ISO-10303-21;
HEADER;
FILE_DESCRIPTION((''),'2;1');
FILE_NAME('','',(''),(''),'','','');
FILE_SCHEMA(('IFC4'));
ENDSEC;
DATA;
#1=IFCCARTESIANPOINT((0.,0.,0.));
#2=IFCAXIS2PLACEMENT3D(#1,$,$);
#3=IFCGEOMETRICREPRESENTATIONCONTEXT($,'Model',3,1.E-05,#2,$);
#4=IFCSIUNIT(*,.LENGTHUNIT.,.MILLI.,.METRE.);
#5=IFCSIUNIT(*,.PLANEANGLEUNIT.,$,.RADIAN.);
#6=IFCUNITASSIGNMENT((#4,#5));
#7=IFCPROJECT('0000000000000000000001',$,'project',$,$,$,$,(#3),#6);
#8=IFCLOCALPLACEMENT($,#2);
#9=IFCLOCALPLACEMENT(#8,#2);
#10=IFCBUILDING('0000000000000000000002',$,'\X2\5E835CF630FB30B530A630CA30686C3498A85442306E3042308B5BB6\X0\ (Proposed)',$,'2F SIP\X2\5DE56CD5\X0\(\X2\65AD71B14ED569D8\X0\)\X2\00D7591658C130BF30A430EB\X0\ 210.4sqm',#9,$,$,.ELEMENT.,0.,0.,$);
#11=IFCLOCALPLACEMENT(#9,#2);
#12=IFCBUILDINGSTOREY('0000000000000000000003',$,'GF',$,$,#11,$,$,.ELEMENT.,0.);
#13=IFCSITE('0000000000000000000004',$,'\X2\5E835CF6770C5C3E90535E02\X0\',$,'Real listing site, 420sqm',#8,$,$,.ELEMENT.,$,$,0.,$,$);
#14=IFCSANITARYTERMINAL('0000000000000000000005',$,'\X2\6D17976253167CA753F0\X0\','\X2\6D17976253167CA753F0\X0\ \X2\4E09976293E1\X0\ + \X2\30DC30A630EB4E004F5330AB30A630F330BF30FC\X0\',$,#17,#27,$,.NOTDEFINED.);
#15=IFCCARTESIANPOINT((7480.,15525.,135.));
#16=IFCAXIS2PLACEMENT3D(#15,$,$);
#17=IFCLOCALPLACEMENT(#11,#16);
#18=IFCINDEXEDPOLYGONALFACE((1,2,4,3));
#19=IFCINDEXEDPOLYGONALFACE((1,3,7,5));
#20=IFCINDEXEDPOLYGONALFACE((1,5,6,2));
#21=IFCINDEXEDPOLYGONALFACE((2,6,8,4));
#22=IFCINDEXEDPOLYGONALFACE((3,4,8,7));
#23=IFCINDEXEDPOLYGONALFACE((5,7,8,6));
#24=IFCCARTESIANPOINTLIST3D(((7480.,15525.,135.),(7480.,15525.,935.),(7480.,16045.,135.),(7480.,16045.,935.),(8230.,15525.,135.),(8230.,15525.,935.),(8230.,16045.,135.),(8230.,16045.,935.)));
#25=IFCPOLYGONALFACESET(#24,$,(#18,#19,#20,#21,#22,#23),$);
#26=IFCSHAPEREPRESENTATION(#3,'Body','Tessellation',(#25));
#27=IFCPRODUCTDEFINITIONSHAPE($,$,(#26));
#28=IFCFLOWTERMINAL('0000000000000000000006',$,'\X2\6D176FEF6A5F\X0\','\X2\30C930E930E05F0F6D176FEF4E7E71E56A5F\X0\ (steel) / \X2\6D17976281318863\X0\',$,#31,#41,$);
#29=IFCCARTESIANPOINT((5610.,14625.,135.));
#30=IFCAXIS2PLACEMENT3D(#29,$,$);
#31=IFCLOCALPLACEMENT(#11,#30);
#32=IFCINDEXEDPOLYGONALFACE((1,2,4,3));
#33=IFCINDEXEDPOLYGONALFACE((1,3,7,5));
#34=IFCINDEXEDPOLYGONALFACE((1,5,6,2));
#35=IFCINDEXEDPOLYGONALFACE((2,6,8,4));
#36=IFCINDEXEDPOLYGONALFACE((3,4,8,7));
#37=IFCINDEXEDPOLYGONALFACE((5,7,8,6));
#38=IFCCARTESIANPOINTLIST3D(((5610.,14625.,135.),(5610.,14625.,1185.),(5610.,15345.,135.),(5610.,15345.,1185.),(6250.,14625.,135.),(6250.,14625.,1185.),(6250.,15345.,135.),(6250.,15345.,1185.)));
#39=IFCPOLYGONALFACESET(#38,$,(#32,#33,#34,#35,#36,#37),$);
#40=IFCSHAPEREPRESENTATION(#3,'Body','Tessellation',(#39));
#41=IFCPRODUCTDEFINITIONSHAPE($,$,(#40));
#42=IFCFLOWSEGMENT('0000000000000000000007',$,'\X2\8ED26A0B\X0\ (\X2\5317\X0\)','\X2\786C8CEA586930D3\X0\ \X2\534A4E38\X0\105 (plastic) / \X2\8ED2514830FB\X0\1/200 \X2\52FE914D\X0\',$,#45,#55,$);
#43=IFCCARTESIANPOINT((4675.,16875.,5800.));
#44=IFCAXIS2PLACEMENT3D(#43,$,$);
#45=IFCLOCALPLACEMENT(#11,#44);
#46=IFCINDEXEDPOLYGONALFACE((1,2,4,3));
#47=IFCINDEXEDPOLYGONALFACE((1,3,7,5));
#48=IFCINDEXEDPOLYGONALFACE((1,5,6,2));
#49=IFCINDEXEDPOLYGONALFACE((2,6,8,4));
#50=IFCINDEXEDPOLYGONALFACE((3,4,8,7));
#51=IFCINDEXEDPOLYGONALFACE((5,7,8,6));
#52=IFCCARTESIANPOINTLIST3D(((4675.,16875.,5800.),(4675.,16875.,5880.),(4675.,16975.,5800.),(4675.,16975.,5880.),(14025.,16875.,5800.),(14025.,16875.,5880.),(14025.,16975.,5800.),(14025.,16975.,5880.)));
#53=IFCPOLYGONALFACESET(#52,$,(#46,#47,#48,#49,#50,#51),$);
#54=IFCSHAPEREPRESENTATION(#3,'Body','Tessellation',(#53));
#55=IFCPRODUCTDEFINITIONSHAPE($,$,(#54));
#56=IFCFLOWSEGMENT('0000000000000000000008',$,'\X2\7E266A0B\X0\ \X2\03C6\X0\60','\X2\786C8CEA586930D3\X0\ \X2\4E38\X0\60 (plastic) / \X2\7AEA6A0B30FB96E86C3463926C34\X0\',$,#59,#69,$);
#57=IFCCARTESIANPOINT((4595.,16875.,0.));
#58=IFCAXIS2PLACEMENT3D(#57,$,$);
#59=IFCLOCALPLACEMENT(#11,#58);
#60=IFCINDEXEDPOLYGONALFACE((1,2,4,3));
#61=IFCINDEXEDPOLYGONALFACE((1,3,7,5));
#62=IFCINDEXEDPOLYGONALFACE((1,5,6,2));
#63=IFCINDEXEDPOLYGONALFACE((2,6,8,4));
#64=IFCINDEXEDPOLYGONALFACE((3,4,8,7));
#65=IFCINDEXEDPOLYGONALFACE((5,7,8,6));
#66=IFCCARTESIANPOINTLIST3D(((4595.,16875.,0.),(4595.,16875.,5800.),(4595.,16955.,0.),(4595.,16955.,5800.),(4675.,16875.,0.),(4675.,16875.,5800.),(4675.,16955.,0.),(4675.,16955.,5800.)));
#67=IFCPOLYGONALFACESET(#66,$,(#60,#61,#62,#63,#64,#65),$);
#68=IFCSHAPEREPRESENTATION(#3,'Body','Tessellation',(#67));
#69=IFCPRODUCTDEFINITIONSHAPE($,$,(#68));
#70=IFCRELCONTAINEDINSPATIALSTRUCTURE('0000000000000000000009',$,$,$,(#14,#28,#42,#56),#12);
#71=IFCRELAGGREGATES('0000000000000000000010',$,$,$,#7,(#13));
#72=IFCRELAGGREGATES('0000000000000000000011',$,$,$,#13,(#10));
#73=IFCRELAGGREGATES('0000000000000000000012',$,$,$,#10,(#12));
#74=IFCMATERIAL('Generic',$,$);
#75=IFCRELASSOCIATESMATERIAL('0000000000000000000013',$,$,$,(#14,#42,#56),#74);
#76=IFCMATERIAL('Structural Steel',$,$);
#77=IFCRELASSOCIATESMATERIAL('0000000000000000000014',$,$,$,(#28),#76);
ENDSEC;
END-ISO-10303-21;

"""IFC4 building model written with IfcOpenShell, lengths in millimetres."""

from ifc_helpers import new_model, si_unit, frame, frame_2d, origin, place, context, project, spatial, rectangle, extrude, material, element, save


model = new_model("IFC4")

# Units and contexts
model_context = context("Model", 3, precision=1e-05, world=origin())
ifc_project = project(units=[si_unit("LENGTHUNIT", "METRE", prefix="MILLI"), si_unit("PLANEANGLEUNIT", "RADIAN")], contexts=[model_context])

# Site, building, storey
site_placement = place(None, origin())
site = spatial("IfcSite", under=ifc_project, at=site_placement, Name="広島県尾道市", ObjectType="Real listing site, 420sqm", CompositionType="ELEMENT", RefElevation=0.0)
building_placement = place(site_placement, origin())
building = spatial("IfcBuilding", under=site, at=building_placement, Name="広島・サウナと水風呂のある家 (Proposed)", ObjectType="2F SIP工法(断熱仕様)×外壁タイル 210.4sqm", CompositionType="ELEMENT", ElevationOfRefHeight=0.0, ElevationOfTerrain=0.0)
storey_placement = place(building_placement, origin())
storey = spatial("IfcBuildingStorey", under=building, at=storey_placement, Name="GF", CompositionType="ELEMENT", Elevation=0.0)

# Sanitary terminal
ifc_material_1 = material(Name="Generic")
sanitary_terminal_placement = place(storey_placement, frame((7480.0, 15525.0, 135.0)))
element("IfcSanitaryTerminal", 1, at=sanitary_terminal_placement, inside=storey, material=ifc_material_1, Name="洗面化粧台", Description="洗面化粧台 三面鏡 + ボウル一体カウンター", PredefinedType="NOTDEFINED", context=model_context, shape_type="SweptSolid", body=[
    extrude(rectangle(XDim=750.0, YDim=520.0, at=frame_2d((375.0, 260.0))), frame((7480.0, 15525.0, 135.0)), (0.0, 0.0, 1.0), 800.0),
])

# Flow terminal
ifc_material_2 = material(Name="Structural Steel")
flow_terminal_placement = place(storey_placement, frame((5610.0, 14625.0, 135.0)))
element("IfcFlowTerminal", 2, at=flow_terminal_placement, inside=storey, material=ifc_material_2, Name="洗濯機", Description="ドラム式洗濯乾燥機 (steel) / 洗面脱衣", context=model_context, shape_type="SweptSolid", body=[
    extrude(rectangle(XDim=640.0, YDim=720.0, at=frame_2d((320.0, 360.0))), frame((5610.0, 14625.0, 135.0)), (0.0, 0.0, 1.0), 1050.0),
])

# Flow segments
flow_segment_1_placement = place(storey_placement, frame((4675.0, 16875.0, 5800.0)))
element("IfcFlowSegment", 3, at=flow_segment_1_placement, inside=storey, material=ifc_material_1, Name="軒樋 (北)", Description="硬質塩ビ 半丸105 (plastic) / 軒先・1/200 勾配", context=model_context, shape_type="SweptSolid", body=[
    extrude(rectangle(XDim=9350.0, YDim=100.0, at=frame_2d((4675.0, 50.0))), frame((4675.0, 16875.0, 5800.0)), (0.0, 0.0, 1.0), 80.0),
])
flow_segment_2_placement = place(storey_placement, frame((4595.0, 16875.0, 0.0)))
element("IfcFlowSegment", 4, at=flow_segment_2_placement, inside=storey, material=ifc_material_1, Name="縦樋 φ60", Description="硬質塩ビ 丸60 (plastic) / 竪樋・雨水排水", context=model_context, shape_type="SweptSolid", body=[
    extrude(rectangle(XDim=80.0, YDim=80.0, at=frame_2d((40.0, 40.0))), frame((4595.0, 16875.0, 0.0)), (0.0, 0.0, 1.0), 5800.0),
])

save(model, "model.ifc")
